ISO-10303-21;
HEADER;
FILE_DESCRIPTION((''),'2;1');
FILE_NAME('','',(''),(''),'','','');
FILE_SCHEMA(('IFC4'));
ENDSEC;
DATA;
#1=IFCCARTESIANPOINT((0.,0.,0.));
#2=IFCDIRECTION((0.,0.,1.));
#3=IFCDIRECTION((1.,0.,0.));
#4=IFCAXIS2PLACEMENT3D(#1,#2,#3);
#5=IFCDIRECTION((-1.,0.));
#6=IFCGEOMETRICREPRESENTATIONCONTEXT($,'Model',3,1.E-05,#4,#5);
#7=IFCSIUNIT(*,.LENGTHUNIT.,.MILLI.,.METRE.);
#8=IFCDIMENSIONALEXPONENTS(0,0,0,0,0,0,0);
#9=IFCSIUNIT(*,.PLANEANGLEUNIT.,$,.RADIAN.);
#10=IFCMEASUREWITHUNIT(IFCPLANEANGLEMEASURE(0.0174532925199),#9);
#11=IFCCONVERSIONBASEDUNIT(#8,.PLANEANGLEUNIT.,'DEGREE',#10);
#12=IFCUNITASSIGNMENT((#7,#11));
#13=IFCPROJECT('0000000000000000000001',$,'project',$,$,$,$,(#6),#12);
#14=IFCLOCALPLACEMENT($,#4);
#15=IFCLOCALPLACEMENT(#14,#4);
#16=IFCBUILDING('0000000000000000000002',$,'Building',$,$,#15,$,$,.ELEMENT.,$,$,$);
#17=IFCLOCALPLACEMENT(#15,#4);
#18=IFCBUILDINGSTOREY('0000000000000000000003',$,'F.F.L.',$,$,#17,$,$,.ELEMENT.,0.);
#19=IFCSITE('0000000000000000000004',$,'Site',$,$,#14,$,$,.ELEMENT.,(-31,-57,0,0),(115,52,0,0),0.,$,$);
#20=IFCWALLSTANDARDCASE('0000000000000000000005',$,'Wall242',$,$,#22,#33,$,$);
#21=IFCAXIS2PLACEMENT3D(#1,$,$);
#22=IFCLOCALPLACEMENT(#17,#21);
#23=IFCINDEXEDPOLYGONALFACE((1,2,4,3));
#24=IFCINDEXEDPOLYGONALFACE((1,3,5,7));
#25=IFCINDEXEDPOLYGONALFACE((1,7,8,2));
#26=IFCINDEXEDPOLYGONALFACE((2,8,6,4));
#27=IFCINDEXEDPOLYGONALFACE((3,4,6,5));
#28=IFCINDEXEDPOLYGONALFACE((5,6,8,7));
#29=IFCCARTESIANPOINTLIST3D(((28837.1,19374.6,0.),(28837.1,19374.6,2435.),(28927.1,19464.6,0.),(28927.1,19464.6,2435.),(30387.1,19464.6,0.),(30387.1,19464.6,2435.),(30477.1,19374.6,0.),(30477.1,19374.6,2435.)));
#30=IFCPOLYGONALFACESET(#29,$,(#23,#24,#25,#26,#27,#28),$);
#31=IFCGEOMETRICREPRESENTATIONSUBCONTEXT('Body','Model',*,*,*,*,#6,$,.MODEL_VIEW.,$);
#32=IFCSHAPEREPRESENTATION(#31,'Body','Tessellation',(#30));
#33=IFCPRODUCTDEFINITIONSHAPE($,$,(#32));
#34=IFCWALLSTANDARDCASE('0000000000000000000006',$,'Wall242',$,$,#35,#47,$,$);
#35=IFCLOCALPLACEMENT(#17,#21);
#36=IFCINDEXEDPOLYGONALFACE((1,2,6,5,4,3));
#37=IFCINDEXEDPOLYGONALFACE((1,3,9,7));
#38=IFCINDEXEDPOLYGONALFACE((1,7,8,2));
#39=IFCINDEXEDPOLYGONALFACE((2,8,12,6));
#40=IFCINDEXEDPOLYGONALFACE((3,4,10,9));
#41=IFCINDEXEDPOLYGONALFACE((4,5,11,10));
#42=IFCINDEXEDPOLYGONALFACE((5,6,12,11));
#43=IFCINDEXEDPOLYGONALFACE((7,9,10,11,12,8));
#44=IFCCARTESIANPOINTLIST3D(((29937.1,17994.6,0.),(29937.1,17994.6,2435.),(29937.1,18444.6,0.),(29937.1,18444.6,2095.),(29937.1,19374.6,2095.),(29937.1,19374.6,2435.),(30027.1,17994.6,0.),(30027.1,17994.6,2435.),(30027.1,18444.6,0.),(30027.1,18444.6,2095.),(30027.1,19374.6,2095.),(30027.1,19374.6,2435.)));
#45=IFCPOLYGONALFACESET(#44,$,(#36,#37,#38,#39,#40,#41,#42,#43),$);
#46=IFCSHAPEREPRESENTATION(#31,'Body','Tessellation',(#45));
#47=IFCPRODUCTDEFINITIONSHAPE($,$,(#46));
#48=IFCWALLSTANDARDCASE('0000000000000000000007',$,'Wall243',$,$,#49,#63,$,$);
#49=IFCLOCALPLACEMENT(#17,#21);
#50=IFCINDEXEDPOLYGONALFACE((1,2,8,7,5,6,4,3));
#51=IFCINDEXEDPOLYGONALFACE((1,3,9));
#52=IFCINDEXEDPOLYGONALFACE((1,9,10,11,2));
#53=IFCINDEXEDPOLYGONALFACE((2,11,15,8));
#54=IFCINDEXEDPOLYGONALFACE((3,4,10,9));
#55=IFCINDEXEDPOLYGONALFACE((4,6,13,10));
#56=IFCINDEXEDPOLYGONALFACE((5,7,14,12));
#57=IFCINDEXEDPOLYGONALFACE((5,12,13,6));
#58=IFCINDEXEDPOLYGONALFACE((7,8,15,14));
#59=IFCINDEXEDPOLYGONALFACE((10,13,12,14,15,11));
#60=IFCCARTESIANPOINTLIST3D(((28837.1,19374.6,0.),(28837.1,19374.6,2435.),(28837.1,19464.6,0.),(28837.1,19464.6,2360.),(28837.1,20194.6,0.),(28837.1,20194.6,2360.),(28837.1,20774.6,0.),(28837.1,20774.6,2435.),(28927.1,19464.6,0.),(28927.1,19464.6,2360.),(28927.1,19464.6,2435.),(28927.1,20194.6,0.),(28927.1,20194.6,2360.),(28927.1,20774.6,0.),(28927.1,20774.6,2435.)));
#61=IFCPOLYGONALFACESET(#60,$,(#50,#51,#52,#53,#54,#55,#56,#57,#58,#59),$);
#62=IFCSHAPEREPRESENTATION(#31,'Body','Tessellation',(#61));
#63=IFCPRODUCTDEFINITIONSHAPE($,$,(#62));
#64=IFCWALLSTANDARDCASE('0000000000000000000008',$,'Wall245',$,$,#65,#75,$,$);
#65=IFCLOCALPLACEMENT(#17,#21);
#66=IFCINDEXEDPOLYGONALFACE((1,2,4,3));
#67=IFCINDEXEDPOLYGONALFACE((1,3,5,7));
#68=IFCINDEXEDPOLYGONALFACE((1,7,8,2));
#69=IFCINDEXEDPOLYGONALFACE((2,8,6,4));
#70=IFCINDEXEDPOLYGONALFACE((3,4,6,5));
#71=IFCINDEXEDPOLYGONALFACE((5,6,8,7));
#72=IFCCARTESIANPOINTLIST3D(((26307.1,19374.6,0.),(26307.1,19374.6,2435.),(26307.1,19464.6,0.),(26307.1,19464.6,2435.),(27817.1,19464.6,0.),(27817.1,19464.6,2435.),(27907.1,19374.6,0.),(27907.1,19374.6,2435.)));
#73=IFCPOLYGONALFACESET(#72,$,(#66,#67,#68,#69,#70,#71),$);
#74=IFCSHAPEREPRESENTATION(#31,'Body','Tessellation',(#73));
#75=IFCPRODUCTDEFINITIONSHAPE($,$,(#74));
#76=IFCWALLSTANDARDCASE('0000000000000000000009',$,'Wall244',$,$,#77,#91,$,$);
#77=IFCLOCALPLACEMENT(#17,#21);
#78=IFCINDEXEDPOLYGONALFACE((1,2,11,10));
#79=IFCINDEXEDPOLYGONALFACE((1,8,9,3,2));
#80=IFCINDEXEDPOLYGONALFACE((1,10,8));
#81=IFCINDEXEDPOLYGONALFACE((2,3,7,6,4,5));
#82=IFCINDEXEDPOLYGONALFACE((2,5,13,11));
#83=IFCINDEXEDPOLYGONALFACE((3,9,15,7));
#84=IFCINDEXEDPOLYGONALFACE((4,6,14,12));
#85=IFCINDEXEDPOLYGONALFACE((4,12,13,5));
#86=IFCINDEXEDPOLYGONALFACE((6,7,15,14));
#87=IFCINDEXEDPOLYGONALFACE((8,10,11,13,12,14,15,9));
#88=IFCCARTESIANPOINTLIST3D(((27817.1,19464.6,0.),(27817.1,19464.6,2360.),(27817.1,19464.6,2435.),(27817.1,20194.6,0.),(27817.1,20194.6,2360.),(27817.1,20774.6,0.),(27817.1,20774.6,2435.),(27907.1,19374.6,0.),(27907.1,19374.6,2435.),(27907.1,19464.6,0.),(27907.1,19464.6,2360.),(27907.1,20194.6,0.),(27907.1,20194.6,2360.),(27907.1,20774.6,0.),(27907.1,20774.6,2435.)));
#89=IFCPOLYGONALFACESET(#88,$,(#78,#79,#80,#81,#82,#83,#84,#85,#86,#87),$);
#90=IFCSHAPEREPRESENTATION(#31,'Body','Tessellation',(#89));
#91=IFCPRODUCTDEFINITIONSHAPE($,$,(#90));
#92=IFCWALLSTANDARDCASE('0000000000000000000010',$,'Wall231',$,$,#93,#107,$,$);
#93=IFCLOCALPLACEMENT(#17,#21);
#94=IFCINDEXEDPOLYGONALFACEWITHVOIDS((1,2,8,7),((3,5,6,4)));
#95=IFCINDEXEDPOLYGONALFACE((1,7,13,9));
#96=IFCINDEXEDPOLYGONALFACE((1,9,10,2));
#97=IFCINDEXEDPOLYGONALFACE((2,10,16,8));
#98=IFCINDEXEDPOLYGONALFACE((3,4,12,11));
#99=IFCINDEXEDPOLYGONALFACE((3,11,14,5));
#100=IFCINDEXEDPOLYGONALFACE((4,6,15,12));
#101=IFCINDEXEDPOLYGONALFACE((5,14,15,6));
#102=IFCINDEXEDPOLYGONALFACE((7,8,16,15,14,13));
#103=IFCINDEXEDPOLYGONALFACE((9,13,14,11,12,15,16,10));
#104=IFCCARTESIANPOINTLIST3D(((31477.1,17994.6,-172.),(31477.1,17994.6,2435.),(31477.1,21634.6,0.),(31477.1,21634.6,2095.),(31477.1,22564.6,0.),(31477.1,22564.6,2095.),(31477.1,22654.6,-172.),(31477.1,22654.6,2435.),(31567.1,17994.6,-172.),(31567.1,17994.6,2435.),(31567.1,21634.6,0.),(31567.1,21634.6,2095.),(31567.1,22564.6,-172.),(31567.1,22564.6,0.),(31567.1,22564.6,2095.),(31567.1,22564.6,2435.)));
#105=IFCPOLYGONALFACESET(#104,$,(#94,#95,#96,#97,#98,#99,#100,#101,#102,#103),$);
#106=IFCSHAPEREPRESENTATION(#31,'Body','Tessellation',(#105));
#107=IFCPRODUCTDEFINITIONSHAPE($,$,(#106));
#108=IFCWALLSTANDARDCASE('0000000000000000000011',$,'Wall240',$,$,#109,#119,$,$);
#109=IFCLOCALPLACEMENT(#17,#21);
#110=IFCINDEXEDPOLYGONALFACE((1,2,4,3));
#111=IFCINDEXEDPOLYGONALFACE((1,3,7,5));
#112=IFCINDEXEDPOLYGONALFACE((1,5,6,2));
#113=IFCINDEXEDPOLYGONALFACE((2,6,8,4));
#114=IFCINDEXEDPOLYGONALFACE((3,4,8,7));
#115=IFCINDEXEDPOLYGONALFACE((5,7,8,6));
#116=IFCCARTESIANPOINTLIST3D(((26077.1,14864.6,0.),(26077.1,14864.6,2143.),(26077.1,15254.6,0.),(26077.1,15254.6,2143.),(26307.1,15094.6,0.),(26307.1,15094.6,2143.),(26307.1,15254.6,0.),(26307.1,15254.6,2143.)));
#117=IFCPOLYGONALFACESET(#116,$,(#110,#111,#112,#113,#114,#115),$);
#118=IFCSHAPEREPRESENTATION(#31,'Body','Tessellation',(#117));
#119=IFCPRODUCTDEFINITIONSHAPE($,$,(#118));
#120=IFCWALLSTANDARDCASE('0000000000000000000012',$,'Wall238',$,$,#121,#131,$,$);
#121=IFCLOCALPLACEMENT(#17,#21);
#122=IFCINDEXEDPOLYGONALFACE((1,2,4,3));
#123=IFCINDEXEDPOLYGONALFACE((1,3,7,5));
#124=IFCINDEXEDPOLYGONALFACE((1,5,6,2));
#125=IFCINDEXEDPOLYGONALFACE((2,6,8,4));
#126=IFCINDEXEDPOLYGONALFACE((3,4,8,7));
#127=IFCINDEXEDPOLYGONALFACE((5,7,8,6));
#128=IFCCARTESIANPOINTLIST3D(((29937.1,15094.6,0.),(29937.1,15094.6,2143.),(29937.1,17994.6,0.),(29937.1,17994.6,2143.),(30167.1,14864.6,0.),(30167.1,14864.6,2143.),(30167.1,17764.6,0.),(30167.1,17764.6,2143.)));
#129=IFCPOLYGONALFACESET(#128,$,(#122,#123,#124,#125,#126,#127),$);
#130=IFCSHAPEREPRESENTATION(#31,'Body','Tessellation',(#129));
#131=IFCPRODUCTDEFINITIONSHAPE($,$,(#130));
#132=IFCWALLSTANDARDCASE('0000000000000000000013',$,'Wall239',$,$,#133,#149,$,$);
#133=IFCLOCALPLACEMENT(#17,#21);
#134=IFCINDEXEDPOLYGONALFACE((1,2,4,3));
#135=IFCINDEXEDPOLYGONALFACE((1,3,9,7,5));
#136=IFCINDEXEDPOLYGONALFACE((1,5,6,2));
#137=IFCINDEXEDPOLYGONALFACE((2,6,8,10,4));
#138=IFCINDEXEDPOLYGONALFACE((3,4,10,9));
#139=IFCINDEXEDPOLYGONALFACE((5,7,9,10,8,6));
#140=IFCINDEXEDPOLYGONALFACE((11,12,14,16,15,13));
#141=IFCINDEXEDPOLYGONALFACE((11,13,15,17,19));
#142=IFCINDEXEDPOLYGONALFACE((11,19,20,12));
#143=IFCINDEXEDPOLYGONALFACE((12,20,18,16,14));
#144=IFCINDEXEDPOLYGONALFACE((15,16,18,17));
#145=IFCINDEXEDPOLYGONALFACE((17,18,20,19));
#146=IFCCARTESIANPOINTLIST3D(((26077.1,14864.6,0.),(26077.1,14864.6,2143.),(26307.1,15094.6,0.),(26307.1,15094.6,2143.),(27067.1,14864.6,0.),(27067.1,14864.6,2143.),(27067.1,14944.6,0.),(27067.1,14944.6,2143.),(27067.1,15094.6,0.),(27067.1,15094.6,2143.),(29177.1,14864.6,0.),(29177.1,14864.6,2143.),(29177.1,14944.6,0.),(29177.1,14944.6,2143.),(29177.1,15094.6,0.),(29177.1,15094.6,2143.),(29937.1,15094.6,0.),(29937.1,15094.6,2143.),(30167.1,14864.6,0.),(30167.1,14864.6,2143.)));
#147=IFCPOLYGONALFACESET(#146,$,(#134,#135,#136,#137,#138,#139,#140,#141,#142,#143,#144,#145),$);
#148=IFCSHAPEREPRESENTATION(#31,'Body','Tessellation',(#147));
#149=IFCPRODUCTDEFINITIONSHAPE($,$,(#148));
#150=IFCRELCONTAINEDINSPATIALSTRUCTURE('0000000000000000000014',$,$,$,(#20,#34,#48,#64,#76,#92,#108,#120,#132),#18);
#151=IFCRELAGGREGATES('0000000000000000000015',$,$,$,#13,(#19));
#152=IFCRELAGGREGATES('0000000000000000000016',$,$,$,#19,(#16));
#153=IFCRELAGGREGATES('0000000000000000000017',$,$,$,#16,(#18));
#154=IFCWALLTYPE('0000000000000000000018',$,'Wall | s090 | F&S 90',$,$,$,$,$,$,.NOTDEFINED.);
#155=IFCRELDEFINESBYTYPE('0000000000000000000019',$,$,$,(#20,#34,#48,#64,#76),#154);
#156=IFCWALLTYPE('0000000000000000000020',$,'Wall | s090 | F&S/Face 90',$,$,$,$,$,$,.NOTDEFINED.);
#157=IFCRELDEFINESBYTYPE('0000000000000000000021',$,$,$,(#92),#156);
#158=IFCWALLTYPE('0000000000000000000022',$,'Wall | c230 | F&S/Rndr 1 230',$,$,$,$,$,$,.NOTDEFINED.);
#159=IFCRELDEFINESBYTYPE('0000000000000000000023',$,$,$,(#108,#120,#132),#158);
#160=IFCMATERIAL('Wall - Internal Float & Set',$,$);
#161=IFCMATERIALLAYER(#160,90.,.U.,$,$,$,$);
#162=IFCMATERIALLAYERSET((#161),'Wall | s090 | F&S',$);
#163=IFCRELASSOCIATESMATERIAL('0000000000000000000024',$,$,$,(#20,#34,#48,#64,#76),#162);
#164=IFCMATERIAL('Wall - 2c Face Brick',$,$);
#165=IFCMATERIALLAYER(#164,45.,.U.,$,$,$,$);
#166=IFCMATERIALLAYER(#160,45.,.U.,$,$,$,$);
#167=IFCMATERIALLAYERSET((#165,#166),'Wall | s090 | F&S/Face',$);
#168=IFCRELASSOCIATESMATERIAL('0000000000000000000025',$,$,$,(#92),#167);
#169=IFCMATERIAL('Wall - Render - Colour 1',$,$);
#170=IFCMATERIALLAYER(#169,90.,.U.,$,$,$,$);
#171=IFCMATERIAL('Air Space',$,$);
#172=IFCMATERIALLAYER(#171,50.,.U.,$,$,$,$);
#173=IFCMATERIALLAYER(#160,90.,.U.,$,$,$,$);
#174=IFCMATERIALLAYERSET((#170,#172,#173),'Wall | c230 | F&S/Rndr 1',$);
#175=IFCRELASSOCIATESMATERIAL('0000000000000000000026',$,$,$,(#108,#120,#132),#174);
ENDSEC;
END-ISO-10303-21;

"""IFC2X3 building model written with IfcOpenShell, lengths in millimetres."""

from ifc_helpers import new_model, entity, si_unit, converted_unit, direction, frame, origin_with_axes, origin_2d_with_axis, place, context, subcontext, project, spatial, polyline, rectangle, outline, extrude, material, layer, layer_set, layer_usage, type_object, element, save


model = new_model("IFC2X3")

# Units and contexts
model_context = context("Model", 3, precision=1e-05, world=origin_with_axes(), true_north=direction((-1.0, 0.0)))
body_context = subcontext(model_context, "Body", "Model", "MODEL_VIEW")
ifc_project = project(units=[si_unit("LENGTHUNIT", "METRE", prefix="MILLI"), converted_unit("PLANEANGLEUNIT", "DEGREE", entity("IfcPlaneAngleMeasure", 0.0174532925199), si_unit("PLANEANGLEUNIT", "RADIAN"), dimensions=[0, 0, 0, 0, 0, 0, 0])], contexts=[model_context])

# Site, building, storey
site_placement = place(None, origin_with_axes())
site = spatial("IfcSite", under=ifc_project, at=site_placement, Name="Site", CompositionType="ELEMENT", RefLatitude=(-31, -57, 0, 0), RefLongitude=(115, 52, 0, 0), RefElevation=0.0)
building_placement = place(site_placement, origin_with_axes())
building = spatial("IfcBuilding", under=site, at=building_placement, Name="Building", CompositionType="ELEMENT")
storey_placement = place(building_placement, origin_with_axes())
storey = spatial("IfcBuildingStorey", under=building, at=storey_placement, Name="F.F.L.", CompositionType="ELEMENT", Elevation=0.0)

# Wall
ifc_material_1 = material(Name="Wall - Internal Float & Set")
ifc_layer_1 = layer(ifc_material_1, 90.0, ventilated="UNKNOWN")
ifc_layer_set_1 = layer_set([ifc_layer_1], Name="Wall | s090 | F&S")
ifc_layer_usage_1 = layer_usage(ifc_layer_set_1, "AXIS2", "POSITIVE", -90.0)
wall_type_1 = type_object("IfcWallType", Name="Wall | s090 | F&S 90", PredefinedType="NOTDEFINED")
wall_1_placement = place(storey_placement, frame((30477.1, 19374.6, 0.0), z_axis=(0.0, 0.0, 1.0), x_axis=(-1.0, 0.0, 0.0)))
element("IfcWallStandardCase", 1, at=wall_1_placement, inside=storey, type_object=wall_type_1, material=ifc_layer_usage_1, Name="Wall242", context=body_context, shape_type="SweptSolid", body=[
    extrude(outline(polyline([(90.0, -90.0), (1550.0, -90.0), (1640.0, 0.0), (0.0, 0.0), (90.0, -90.0)])), origin_with_axes(), (0.0, 0.0, 1.0), 2435.0),
])

# Walls, openings
ifc_layer_usage_2 = layer_usage(ifc_layer_set_1, "AXIS2", "POSITIVE", -90.0)
wall_2_placement = place(storey_placement, frame((29937.1, 17994.6, 0.0), z_axis=(0.0, 0.0, 1.0), x_axis=(0.0, 1.0, 0.0)))
wall_2 = element("IfcWallStandardCase", 2, at=wall_2_placement, inside=storey, type_object=wall_type_1, material=ifc_layer_usage_2, Name="Wall242", context=body_context, shape_type="SweptSolid", body=[
    extrude(outline(polyline([(0.0, -90.0), (1380.0, -90.0), (1380.0, 0.0), (0.0, 0.0), (0.0, -90.0)])), origin_with_axes(), (0.0, 0.0, 1.0), 2435.0),
])
opening_1_placement = place(wall_2_placement, frame((915.0, 0.0, 0.0), z_axis=(0.0, 0.0, 1.0), x_axis=(1.0, 0.0, 0.0)))
element("IfcOpeningElement", 3, at=opening_1_placement, cuts=wall_2, context=body_context, shape_type="SweptSolid", body=[
    extrude(rectangle(XDim=930.0, YDim=2095.0, at=origin_2d_with_axis()), frame((0.0, -90.0, 1047.5), z_axis=(0.0, 1.0, 0.0), x_axis=(1.0, 0.0, 0.0)), (0.0, 0.0, 1.0), 180.0),
])
ifc_layer_usage_3 = layer_usage(ifc_layer_set_1, "AXIS2", "POSITIVE", -90.0)
wall_3_placement = place(storey_placement, frame((28837.1, 19374.6, 0.0), z_axis=(0.0, 0.0, 1.0), x_axis=(0.0, 1.0, 0.0)))
wall_3 = element("IfcWallStandardCase", 4, at=wall_3_placement, inside=storey, type_object=wall_type_1, material=ifc_layer_usage_3, Name="Wall243", context=body_context, shape_type="SweptSolid", body=[
    extrude(outline(polyline([(90.0, -90.0), (1400.0, -90.0), (1400.0, 0.0), (0.0, 0.0), (90.0, -90.0)])), origin_with_axes(), (0.0, 0.0, 1.0), 2435.0),
])
opening_2_placement = place(wall_3_placement, frame((455.0, 0.0, 0.0), z_axis=(0.0, 0.0, 1.0), x_axis=(1.0, 0.0, 0.0)))
element("IfcOpeningElement", 5, at=opening_2_placement, cuts=wall_3, context=body_context, shape_type="SweptSolid", body=[
    extrude(rectangle(XDim=730.0, YDim=2360.0, at=origin_2d_with_axis()), frame((0.0, -90.0, 1180.0), z_axis=(0.0, -1.0, 0.0), x_axis=(-1.0, 0.0, 0.0)), (0.0, 0.0, -1.0), 180.0),
])

# Wall
ifc_layer_usage_4 = layer_usage(ifc_layer_set_1, "AXIS2", "POSITIVE", -90.0)
wall_4_placement = place(storey_placement, frame((27907.1, 19374.6, 0.0), z_axis=(0.0, 0.0, 1.0), x_axis=(-1.0, 0.0, 0.0)))
element("IfcWallStandardCase", 6, at=wall_4_placement, inside=storey, type_object=wall_type_1, material=ifc_layer_usage_4, Name="Wall245", context=body_context, shape_type="SweptSolid", body=[
    extrude(outline(polyline([(90.0, -90.0), (1600.0, -90.0), (1600.0, 0.0), (0.0, 0.0), (90.0, -90.0)])), origin_with_axes(), (0.0, 0.0, 1.0), 2435.0),
])

# Walls, openings
ifc_layer_usage_5 = layer_usage(ifc_layer_set_1, "AXIS2", "POSITIVE", -90.0)
wall_5_placement = place(storey_placement, frame((27907.1, 20774.6, 0.0), z_axis=(0.0, 0.0, 1.0), x_axis=(0.0, -1.0, 0.0)))
wall_5 = element("IfcWallStandardCase", 7, at=wall_5_placement, inside=storey, type_object=wall_type_1, material=ifc_layer_usage_5, Name="Wall244", context=body_context, shape_type="SweptSolid", body=[
    extrude(outline(polyline([(0.0, -90.0), (1310.0, -90.0), (1400.0, 0.0), (0.0, 0.0), (0.0, -90.0)])), origin_with_axes(), (0.0, 0.0, 1.0), 2435.0),
])
opening_3_placement = place(wall_5_placement, frame((945.0, 0.0, 0.0), z_axis=(0.0, 0.0, 1.0), x_axis=(1.0, 0.0, 0.0)))
element("IfcOpeningElement", 8, at=opening_3_placement, cuts=wall_5, context=body_context, shape_type="SweptSolid", body=[
    extrude(rectangle(XDim=730.0, YDim=2360.0, at=origin_2d_with_axis()), frame((0.0, -90.0, 1180.0), z_axis=(0.0, 1.0, 0.0), x_axis=(1.0, 0.0, 0.0)), (0.0, 0.0, 1.0), 180.0),
])
ifc_material_2 = material(Name="Wall - 2c Face Brick")
ifc_layer_2 = layer(ifc_material_2, 45.0, ventilated="UNKNOWN")
ifc_layer_3 = layer(ifc_material_1, 45.0, ventilated="UNKNOWN")
ifc_layer_set_2 = layer_set([ifc_layer_2, ifc_layer_3], Name="Wall | s090 | F&S/Face")
ifc_layer_usage_6 = layer_usage(ifc_layer_set_2, "AXIS2", "NEGATIVE", 90.0)
wall_type_2 = type_object("IfcWallType", Name="Wall | s090 | F&S/Face 90", PredefinedType="NOTDEFINED")
wall_6_placement = place(storey_placement, frame((31477.1, 22654.6, -172.0), z_axis=(0.0, 0.0, 1.0), x_axis=(0.0, -1.0, 0.0)))
wall_6 = element("IfcWallStandardCase", 9, at=wall_6_placement, inside=storey, type_object=wall_type_2, material=ifc_layer_usage_6, Name="Wall231", context=body_context, shape_type="SweptSolid", body=[
    extrude(outline(polyline([(0.0, 0.0), (4660.0, 0.0), (4660.0, 90.0), (90.0, 90.0), (0.0, 0.0)])), origin_with_axes(), (0.0, 0.0, 1.0), 2607.0),
])
opening_4_placement = place(wall_6_placement, frame((555.0, 0.0, 172.0), z_axis=(0.0, 0.0, 1.0), x_axis=(1.0, 0.0, 0.0)))
element("IfcOpeningElement", 10, at=opening_4_placement, cuts=wall_6, context=body_context, shape_type="SweptSolid", body=[
    extrude(rectangle(XDim=930.0, YDim=2095.0, at=origin_2d_with_axis()), frame((0.0, 90.0, 1047.5), z_axis=(0.0, 1.0, 0.0), x_axis=(1.0, 0.0, 0.0)), (0.0, 0.0, -1.0), 180.0),
])

# Walls
ifc_material_3 = material(Name="Wall - Render - Colour 1")
ifc_layer_4 = layer(ifc_material_3, 90.0, ventilated="UNKNOWN")
ifc_material_4 = material(Name="Air Space")
ifc_layer_5 = layer(ifc_material_4, 50.0, ventilated="UNKNOWN")
ifc_layer_6 = layer(ifc_material_1, 90.0, ventilated="UNKNOWN")
ifc_layer_set_3 = layer_set([ifc_layer_4, ifc_layer_5, ifc_layer_6], Name="Wall | c230 | F&S/Rndr 1")
ifc_layer_usage_7 = layer_usage(ifc_layer_set_3, "AXIS2", "NEGATIVE", 0.0)
wall_type_3 = type_object("IfcWallType", Name="Wall | c230 | F&S/Rndr 1 230", PredefinedType="NOTDEFINED")
wall_7_placement = place(storey_placement, frame((26077.1, 14864.6, 0.0), z_axis=(0.0, 0.0, 1.0), x_axis=(0.0, 1.0, 0.0)))
element("IfcWallStandardCase", 11, at=wall_7_placement, inside=storey, type_object=wall_type_3, material=ifc_layer_usage_7, Name="Wall240", context=body_context, shape_type="SweptSolid", body=[
    extrude(outline(polyline([(230.0, -230.0), (390.0, -230.0), (390.0, 0.0), (0.0, 0.0), (230.0, -230.0)])), origin_with_axes(), (0.0, 0.0, 1.0), 2143.0),
])
ifc_layer_usage_8 = layer_usage(ifc_layer_set_3, "AXIS2", "NEGATIVE", 0.0)
wall_8_placement = place(storey_placement, frame((30167.1, 17764.6, 0.0), z_axis=(0.0, 0.0, 1.0), x_axis=(0.0, -1.0, 0.0)))
element("IfcWallStandardCase", 12, at=wall_8_placement, inside=storey, type_object=wall_type_3, material=ifc_layer_usage_8, Name="Wall238", context=body_context, shape_type="SweptSolid", body=[
    extrude(outline(polyline([(-230.0, -230.0), (2670.0, -230.0), (2900.0, 0.0), (0.0, 0.0), (-230.0, -230.0)])), origin_with_axes(), (0.0, 0.0, 1.0), 2143.0),
])

# Wall, opening
ifc_layer_usage_9 = layer_usage(ifc_layer_set_3, "AXIS2", "NEGATIVE", 0.0)
wall_9_placement = place(storey_placement, frame((30167.1, 14864.6, 0.0), z_axis=(0.0, 0.0, 1.0), x_axis=(-1.0, 0.0, 0.0)))
wall_9 = element("IfcWallStandardCase", 13, at=wall_9_placement, inside=storey, type_object=wall_type_3, material=ifc_layer_usage_9, Name="Wall239", context=body_context, shape_type="SweptSolid", body=[
    extrude(outline(polyline([(230.0, -230.0), (3860.0, -230.0), (4090.0, 0.0), (0.0, 0.0), (230.0, -230.0)])), origin_with_axes(), (0.0, 0.0, 1.0), 2143.0),
])
opening_5_placement = place(wall_9_placement, frame((2045.0, 0.0, 0.0), z_axis=(0.0, 0.0, 1.0), x_axis=(1.0, 0.0, 0.0)))
element("IfcOpeningElement", 14, at=opening_5_placement, cuts=wall_9, context=body_context, shape_type="SweptSolid", body=[
    extrude(rectangle(XDim=2110.0, YDim=2143.0, at=origin_2d_with_axis()), frame((0.0, 15070.0, 1071.5), z_axis=(0.0, -1.0, 0.0), x_axis=(-1.0, 0.0, 0.0)), (0.0, 0.0, 1.0), 15380.0),
    extrude(rectangle(XDim=2110.0, YDim=2143.0, at=origin_2d_with_axis()), frame((0.0, -80.0, 1071.5), z_axis=(0.0, 1.0, 0.0), x_axis=(-1.0, 0.0, 0.0)), (0.0, 0.0, 1.0), 310.0),
])

save(model, "model.ifc")
